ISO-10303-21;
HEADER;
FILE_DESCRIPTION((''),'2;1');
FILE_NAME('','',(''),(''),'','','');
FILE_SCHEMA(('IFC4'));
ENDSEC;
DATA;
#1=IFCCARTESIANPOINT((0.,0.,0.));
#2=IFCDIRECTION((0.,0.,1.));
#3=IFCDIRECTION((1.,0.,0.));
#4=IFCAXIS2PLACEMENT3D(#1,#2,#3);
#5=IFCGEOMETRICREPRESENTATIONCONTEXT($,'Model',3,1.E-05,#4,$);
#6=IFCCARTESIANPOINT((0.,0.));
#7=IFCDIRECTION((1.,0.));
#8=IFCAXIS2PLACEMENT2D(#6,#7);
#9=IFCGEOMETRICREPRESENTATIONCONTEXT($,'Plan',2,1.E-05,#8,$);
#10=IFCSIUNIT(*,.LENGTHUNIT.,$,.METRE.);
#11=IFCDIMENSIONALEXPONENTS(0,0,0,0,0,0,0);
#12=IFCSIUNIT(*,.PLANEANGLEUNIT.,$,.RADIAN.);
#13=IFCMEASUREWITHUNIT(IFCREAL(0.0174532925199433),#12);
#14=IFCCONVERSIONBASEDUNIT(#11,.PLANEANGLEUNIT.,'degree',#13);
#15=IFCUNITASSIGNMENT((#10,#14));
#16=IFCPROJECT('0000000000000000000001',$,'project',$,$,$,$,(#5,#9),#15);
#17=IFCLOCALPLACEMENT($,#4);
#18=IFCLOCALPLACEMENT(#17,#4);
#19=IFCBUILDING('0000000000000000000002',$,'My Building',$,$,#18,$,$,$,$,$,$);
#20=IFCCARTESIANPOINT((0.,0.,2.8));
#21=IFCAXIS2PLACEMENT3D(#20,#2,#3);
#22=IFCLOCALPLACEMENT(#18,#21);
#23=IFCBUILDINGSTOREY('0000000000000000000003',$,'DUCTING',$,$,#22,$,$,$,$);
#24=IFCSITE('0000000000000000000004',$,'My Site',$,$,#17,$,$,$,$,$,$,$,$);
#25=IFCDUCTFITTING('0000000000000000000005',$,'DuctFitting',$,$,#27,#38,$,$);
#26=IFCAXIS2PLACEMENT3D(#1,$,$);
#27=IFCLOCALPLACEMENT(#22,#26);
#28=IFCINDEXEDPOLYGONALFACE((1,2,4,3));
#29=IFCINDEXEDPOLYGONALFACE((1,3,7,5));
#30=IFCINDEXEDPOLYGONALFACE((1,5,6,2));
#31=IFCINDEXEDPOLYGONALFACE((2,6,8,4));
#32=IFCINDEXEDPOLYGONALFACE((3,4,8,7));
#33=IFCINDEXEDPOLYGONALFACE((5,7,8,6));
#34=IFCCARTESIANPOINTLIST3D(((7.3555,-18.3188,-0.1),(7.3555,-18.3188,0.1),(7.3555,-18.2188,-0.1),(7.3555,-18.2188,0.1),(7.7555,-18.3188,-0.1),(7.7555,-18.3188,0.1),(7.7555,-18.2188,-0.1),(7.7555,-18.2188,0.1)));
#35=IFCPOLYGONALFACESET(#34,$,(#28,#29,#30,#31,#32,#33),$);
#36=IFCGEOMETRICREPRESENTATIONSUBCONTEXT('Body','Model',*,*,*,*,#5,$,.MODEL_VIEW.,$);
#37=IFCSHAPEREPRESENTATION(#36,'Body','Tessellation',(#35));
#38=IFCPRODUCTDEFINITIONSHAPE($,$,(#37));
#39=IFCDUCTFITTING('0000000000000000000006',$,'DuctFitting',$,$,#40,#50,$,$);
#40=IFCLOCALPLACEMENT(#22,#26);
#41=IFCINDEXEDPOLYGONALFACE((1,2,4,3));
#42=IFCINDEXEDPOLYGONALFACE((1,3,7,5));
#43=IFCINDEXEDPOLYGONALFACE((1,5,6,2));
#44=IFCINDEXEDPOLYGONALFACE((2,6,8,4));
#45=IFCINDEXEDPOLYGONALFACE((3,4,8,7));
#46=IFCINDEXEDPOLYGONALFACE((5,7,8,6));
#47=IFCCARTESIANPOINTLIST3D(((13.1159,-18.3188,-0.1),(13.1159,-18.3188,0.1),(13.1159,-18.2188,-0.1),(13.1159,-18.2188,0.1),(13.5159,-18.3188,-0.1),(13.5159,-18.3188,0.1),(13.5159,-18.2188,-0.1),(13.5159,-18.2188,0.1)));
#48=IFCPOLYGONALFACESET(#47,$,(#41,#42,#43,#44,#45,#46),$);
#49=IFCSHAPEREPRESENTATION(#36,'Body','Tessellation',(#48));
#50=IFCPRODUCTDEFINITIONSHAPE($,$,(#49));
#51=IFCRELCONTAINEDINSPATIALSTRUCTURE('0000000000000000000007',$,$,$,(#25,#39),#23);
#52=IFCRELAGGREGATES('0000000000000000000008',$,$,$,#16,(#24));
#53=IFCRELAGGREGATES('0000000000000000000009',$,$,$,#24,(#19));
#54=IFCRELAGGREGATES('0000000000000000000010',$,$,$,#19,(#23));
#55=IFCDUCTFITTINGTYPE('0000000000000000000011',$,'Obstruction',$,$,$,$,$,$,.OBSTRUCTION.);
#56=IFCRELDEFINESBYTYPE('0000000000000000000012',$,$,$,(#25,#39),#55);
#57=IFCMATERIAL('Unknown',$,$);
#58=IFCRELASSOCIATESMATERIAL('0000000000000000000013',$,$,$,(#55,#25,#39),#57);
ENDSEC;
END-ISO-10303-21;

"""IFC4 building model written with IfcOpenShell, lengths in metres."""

from ifc_helpers import new_model, entity, si_unit, converted_unit, frame, origin_with_axes, origin_2d_with_axis, place, context, subcontext, project, spatial, rectangle, extrude, material, material_profile, profile_set, profile_usage, type_object, element, save


model = new_model("IFC4")

# Units and contexts
model_context = context("Model", 3, precision=1e-05, world=origin_with_axes())
plan_context = context("Plan", 2, precision=1e-05, world=origin_2d_with_axis())
body_context = subcontext(model_context, "Body", "Model", "MODEL_VIEW")
ifc_project = project(units=[si_unit("LENGTHUNIT", "METRE"), converted_unit("PLANEANGLEUNIT", "degree", entity("IfcReal", 0.0174532925199433), si_unit("PLANEANGLEUNIT", "RADIAN"), dimensions=[0, 0, 0, 0, 0, 0, 0])], contexts=[model_context, plan_context])

# Site, building, storey
site_placement = place(None, origin_with_axes())
site = spatial("IfcSite", under=ifc_project, at=site_placement, Name="My Site")
building_placement = place(site_placement, origin_with_axes())
building = spatial("IfcBuilding", under=site, at=building_placement, Name="My Building")
storey_placement = place(building_placement, frame((0.0, 0.0, 2.8), z_axis=(0.0, 0.0, 1.0), x_axis=(1.0, 0.0, 0.0)))
storey = spatial("IfcBuildingStorey", under=building, at=storey_placement, Name="DUCTING")

# Shared definitions
ifc_material = material(Name="Unknown")

# Duct fittings
ifc_material_profile_1 = material_profile(ifc_material, rectangle(XDim=0.4, YDim=0.2))
ifc_profile_set_1 = profile_set([ifc_material_profile_1])
duct_fitting_type_1 = type_object("IfcDuctFittingType", Name="Obstruction", PredefinedType="OBSTRUCTION", material=ifc_profile_set_1)
ifc_profile_usage_1 = profile_usage(ifc_profile_set_1, cardinal=5)
duct_fitting_1_placement = place(storey_placement, frame((7.5555, -18.2188, 0.0), z_axis=(0.0, -1.0, 0.0), x_axis=(1.0, 0.0, 0.0)))
element("IfcDuctFitting", 1, at=duct_fitting_1_placement, inside=storey, type_object=duct_fitting_type_1, material=ifc_profile_usage_1, Name="DuctFitting", context=body_context, shape_type="SweptSolid", body=[
    extrude(rectangle(XDim=0.4, YDim=0.2), origin_with_axes(), (0.0, 0.0, 1.0), 0.1),
])
ifc_profile_usage_2 = profile_usage(ifc_profile_set_1, cardinal=5)
duct_fitting_2_placement = place(storey_placement, frame((13.3159, -18.2188, 0.0), z_axis=(0.0, -1.0, 0.0), x_axis=(1.0, 0.0, 0.0)))
element("IfcDuctFitting", 2, at=duct_fitting_2_placement, inside=storey, type_object=duct_fitting_type_1, material=ifc_profile_usage_2, Name="DuctFitting", context=body_context, shape_type="SweptSolid", body=[
    extrude(rectangle(XDim=0.4, YDim=0.2), origin_with_axes(), (0.0, 0.0, 1.0), 0.1),
])

save(model, "model.ifc")
